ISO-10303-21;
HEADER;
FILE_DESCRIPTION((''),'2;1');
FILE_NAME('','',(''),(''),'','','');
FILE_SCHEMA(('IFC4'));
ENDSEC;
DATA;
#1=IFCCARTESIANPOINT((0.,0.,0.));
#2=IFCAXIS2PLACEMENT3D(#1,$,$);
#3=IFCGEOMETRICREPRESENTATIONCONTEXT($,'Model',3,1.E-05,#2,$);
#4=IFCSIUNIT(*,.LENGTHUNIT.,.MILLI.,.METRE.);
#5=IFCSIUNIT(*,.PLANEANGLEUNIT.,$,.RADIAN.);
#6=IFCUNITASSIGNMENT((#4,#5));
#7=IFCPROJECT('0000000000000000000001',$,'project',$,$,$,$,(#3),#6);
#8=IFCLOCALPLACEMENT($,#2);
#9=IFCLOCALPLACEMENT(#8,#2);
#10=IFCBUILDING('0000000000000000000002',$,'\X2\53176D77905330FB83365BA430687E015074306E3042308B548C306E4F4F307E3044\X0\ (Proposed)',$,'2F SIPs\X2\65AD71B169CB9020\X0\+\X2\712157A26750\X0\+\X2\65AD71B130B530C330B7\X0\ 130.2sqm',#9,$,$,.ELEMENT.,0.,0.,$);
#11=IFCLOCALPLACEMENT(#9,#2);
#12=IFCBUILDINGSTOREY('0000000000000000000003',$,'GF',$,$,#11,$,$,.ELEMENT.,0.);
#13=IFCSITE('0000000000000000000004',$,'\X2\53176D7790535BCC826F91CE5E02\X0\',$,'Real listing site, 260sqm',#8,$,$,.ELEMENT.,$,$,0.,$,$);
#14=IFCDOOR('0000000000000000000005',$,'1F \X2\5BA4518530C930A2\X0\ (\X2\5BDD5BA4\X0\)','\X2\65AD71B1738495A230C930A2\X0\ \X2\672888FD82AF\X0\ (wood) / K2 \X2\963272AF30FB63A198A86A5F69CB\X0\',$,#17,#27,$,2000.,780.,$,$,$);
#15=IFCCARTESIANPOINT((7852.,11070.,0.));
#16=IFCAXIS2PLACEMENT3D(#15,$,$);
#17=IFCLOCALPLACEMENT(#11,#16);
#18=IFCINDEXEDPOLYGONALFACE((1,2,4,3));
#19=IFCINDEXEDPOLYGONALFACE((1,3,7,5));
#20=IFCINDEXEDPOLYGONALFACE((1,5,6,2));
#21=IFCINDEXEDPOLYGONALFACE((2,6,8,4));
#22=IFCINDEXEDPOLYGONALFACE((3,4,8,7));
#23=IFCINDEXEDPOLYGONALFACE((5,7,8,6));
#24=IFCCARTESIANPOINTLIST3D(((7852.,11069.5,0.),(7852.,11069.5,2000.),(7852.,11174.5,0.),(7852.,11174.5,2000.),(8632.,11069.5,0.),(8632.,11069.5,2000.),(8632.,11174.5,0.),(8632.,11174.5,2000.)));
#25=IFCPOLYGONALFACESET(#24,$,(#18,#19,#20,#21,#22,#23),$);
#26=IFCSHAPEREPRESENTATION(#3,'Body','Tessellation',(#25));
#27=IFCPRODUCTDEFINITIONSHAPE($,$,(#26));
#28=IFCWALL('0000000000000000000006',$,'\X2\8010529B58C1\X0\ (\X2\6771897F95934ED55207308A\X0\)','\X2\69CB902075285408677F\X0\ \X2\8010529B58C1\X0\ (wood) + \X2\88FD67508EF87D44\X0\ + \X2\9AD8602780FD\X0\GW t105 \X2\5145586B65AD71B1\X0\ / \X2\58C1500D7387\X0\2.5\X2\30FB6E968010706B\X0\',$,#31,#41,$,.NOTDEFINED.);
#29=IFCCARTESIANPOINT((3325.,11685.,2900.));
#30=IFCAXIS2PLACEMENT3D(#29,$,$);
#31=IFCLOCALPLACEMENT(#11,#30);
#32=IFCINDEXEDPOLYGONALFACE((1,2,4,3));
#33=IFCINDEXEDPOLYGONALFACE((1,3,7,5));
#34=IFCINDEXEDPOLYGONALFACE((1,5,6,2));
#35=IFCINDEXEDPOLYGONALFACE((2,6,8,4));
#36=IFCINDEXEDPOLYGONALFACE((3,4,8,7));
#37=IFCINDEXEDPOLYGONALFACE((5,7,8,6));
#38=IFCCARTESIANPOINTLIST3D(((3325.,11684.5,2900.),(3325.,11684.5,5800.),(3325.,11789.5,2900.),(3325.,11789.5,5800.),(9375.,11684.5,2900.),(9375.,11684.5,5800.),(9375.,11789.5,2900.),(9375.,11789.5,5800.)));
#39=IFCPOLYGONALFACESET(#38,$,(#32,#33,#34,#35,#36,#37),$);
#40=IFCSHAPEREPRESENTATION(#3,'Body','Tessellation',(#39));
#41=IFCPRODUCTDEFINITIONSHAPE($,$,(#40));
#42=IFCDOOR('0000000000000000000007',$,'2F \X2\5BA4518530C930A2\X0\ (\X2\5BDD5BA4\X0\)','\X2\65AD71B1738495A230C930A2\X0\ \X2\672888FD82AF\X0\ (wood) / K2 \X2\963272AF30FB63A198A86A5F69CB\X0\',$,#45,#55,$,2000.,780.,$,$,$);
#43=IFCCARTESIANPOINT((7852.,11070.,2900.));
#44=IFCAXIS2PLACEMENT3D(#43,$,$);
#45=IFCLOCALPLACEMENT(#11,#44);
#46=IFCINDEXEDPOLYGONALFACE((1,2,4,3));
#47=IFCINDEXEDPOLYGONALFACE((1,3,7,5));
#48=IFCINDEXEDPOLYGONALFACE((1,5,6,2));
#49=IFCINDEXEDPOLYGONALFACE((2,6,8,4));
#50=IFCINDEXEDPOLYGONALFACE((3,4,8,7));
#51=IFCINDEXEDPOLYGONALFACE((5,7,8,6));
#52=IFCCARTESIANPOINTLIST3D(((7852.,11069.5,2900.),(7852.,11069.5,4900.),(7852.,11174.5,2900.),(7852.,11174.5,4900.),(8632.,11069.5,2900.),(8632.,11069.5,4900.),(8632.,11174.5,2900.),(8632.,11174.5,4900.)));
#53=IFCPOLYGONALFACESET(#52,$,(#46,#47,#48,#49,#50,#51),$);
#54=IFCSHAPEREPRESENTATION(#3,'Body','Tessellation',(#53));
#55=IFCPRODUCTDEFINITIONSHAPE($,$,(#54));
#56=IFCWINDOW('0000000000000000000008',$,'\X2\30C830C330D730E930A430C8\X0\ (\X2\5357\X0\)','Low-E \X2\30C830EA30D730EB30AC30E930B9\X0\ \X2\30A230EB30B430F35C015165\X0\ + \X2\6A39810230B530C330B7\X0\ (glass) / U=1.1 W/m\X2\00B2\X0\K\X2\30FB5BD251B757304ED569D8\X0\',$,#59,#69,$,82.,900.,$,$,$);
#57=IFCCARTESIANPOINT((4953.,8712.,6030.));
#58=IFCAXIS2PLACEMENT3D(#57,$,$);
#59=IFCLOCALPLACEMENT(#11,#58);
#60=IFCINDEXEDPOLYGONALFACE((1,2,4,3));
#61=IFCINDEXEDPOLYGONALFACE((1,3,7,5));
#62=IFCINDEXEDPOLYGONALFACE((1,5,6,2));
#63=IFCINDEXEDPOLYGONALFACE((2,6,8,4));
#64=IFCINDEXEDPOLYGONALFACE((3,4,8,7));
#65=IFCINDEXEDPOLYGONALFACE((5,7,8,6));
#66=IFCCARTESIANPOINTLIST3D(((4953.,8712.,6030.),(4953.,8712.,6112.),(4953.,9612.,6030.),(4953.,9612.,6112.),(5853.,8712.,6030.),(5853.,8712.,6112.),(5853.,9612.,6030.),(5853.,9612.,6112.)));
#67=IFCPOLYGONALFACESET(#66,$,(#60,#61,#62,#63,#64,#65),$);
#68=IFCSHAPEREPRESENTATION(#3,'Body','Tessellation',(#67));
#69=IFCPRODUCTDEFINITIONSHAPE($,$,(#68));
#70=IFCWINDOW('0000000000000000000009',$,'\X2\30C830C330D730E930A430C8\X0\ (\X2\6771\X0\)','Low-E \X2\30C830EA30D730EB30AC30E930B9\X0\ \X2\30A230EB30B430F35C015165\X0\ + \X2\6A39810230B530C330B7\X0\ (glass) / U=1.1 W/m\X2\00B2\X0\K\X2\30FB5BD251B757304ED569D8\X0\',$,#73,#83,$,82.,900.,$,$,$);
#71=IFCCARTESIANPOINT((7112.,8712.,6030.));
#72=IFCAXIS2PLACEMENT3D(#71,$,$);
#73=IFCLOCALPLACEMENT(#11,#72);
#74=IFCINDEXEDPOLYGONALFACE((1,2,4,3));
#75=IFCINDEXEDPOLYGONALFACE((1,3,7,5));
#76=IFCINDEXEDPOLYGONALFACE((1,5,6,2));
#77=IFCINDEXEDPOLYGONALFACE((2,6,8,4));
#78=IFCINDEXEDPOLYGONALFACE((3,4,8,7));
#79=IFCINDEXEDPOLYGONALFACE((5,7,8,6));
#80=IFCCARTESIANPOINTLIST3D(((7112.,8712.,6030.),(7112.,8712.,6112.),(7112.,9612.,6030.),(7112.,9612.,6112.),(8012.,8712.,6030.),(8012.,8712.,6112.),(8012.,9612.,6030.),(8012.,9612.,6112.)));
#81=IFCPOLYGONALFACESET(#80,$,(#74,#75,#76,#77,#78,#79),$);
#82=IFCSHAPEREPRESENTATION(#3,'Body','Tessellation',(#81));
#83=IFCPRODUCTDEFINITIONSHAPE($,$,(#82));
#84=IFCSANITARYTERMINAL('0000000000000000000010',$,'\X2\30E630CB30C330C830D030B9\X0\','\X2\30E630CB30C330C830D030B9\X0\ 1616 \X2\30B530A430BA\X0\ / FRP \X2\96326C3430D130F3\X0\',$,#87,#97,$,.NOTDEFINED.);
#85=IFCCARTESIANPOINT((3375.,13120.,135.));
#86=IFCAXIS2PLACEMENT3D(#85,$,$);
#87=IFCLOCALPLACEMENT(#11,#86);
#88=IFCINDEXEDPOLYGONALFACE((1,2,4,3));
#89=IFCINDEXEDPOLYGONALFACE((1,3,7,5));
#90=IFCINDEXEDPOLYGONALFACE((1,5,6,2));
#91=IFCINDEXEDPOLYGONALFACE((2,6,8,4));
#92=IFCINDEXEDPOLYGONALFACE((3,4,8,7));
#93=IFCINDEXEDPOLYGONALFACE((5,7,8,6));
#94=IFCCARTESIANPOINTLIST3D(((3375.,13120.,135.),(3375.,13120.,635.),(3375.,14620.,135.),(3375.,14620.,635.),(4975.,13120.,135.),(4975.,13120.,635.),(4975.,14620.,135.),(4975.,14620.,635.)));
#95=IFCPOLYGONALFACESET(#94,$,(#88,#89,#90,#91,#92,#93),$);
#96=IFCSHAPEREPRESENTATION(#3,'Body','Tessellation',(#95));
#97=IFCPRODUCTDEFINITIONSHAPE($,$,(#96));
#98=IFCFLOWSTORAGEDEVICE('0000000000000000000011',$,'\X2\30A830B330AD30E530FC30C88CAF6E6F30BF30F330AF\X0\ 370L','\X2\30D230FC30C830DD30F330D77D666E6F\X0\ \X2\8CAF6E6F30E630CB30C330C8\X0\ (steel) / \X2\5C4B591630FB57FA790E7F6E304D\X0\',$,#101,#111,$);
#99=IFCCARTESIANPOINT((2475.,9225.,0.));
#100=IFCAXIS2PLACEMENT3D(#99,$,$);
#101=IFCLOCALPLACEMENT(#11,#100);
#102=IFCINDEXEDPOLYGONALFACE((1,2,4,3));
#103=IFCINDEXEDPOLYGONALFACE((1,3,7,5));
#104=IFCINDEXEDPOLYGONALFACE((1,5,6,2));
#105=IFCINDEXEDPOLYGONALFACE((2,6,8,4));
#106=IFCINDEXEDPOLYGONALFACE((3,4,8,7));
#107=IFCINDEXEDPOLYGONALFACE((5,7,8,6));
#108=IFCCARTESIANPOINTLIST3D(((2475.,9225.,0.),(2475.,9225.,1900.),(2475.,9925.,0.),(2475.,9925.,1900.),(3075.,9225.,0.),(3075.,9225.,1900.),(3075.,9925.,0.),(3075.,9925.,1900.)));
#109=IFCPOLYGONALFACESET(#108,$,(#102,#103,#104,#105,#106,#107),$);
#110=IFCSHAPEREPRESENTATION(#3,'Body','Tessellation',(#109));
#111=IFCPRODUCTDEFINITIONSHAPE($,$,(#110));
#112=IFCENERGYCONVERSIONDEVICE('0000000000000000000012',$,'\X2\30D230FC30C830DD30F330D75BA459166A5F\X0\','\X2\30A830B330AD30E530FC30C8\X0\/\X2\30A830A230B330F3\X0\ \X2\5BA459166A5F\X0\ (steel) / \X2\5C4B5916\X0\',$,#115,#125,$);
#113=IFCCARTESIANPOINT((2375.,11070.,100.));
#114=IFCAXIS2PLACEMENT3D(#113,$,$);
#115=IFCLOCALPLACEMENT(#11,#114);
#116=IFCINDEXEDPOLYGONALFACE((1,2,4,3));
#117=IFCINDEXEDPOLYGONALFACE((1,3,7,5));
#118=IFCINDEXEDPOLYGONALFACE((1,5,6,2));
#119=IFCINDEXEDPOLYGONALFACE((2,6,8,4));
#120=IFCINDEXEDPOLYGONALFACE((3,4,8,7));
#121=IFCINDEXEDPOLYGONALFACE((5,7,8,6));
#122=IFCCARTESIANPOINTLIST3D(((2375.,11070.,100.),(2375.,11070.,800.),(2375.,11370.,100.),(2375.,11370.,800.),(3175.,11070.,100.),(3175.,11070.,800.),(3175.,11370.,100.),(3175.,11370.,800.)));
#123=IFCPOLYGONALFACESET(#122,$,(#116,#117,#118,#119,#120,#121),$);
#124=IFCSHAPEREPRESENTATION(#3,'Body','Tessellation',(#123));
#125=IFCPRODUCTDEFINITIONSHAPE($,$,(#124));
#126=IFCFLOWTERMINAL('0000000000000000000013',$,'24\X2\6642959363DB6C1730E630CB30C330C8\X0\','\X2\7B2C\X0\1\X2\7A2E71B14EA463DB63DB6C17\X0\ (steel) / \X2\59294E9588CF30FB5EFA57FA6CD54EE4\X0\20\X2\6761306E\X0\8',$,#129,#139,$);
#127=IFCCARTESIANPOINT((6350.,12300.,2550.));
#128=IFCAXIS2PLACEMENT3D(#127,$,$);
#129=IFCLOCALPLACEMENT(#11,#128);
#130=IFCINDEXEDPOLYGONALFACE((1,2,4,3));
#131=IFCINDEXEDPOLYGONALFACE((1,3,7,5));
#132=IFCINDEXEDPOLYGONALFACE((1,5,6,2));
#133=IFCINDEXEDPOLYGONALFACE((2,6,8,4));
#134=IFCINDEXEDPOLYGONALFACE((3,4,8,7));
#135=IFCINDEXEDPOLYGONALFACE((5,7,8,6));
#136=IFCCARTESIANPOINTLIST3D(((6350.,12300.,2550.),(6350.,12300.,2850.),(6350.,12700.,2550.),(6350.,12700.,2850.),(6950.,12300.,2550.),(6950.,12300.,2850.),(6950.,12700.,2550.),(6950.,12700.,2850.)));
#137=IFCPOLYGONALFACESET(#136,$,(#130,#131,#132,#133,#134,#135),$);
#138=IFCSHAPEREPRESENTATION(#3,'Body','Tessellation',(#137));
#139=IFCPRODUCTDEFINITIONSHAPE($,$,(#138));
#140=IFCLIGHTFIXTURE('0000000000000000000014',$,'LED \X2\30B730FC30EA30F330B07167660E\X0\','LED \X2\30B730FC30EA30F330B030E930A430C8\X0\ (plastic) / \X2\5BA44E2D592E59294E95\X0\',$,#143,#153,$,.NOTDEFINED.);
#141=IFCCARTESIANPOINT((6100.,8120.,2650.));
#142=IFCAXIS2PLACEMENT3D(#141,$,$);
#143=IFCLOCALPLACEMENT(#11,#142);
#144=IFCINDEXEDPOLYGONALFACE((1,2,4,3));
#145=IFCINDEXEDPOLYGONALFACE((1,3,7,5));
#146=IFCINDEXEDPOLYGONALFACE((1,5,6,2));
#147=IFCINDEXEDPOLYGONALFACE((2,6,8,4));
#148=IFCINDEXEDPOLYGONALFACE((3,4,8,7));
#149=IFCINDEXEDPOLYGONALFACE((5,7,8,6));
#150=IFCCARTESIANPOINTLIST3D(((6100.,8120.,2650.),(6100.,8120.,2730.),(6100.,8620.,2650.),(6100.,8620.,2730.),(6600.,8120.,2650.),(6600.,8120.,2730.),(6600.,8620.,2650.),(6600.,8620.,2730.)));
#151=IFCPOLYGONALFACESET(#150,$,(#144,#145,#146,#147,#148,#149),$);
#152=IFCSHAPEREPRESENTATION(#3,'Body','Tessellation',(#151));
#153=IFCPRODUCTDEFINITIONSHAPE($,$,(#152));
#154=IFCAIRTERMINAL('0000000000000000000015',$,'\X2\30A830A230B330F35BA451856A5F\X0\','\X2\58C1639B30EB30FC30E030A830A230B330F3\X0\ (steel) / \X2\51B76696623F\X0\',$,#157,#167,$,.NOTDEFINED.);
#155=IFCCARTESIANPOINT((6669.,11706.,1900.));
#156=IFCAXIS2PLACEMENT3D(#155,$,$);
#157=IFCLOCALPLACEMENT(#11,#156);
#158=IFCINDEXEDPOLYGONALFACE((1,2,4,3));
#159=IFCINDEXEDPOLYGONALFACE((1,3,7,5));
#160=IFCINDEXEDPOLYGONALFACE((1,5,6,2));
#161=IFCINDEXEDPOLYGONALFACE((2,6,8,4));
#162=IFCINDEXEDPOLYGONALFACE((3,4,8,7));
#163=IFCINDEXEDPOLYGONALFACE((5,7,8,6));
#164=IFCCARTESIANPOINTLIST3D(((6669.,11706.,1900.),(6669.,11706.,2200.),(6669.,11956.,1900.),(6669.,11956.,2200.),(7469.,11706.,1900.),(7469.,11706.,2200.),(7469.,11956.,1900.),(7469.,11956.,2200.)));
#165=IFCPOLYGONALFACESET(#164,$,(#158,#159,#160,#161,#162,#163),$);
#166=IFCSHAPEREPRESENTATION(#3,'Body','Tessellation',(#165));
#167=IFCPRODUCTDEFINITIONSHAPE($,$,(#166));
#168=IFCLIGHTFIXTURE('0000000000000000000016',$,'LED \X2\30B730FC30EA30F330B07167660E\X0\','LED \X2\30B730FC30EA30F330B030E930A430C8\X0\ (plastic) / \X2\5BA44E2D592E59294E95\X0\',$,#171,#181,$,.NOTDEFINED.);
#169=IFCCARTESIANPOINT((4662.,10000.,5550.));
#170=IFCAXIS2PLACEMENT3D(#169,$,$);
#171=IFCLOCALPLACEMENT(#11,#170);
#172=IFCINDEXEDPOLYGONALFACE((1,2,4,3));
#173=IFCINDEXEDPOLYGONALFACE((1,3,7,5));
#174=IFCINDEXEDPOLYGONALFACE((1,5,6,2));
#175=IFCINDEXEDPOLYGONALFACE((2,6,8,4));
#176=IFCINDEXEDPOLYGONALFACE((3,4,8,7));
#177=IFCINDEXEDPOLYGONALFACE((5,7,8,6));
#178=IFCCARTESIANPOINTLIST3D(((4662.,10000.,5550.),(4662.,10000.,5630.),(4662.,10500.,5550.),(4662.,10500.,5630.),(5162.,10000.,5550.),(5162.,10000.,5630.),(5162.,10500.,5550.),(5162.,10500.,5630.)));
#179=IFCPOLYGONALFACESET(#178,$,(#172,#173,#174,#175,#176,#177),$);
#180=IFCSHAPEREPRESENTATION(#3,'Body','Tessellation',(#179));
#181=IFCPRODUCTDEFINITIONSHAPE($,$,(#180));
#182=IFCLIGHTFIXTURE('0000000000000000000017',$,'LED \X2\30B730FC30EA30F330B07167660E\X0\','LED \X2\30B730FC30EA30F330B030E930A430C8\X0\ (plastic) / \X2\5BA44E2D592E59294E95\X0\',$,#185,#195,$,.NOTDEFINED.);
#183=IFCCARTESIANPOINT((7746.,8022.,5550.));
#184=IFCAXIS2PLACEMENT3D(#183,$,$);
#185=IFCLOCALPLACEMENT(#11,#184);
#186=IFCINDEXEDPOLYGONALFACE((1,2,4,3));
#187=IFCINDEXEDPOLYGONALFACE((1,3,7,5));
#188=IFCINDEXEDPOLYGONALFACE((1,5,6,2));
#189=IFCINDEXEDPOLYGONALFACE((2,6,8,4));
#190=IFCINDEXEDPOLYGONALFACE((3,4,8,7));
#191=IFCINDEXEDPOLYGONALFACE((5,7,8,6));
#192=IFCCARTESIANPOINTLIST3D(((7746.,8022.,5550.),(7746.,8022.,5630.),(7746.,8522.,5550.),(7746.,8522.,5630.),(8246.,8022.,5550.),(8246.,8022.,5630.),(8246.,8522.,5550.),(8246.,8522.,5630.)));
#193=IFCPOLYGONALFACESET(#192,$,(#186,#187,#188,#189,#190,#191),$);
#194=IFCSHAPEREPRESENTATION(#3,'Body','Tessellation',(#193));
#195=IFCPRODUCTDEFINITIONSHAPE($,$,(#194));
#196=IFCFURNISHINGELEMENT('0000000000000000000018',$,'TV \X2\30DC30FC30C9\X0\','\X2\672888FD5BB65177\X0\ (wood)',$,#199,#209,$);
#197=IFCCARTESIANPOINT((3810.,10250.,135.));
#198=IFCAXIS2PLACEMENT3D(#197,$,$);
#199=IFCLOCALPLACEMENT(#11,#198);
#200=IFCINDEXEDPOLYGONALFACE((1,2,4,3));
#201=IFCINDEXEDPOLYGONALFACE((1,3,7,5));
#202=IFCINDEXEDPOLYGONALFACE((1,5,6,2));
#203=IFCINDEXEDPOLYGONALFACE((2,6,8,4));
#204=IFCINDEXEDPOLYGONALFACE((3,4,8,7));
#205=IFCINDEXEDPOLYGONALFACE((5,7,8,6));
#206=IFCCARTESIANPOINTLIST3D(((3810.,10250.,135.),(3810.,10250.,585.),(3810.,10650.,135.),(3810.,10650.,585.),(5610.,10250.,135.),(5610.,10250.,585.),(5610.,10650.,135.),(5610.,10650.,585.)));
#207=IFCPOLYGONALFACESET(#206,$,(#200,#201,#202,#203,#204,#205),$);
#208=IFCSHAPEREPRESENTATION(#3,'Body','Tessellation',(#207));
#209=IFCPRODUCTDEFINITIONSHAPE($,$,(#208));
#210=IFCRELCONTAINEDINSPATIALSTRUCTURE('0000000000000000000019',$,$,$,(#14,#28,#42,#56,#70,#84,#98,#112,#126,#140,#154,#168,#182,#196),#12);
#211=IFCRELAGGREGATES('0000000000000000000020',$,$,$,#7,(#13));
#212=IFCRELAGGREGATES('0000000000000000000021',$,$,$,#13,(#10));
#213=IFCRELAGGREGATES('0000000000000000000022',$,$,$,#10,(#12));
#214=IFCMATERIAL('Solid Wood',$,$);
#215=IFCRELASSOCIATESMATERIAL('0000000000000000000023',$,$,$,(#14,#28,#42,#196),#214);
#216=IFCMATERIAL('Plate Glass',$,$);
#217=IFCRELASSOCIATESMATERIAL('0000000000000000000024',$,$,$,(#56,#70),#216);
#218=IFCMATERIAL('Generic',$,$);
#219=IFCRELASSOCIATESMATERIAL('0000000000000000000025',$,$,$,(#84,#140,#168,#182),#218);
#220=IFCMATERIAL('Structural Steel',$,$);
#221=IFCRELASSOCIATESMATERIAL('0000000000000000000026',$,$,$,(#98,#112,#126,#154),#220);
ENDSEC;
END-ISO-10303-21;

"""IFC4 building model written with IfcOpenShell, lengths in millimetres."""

from ifc_helpers import new_model, si_unit, frame, frame_2d, origin, place, context, project, spatial, rectangle, extrude, material, element, save


model = new_model("IFC4")

# Units and contexts
model_context = context("Model", 3, precision=1e-05, world=origin())
ifc_project = project(units=[si_unit("LENGTHUNIT", "METRE", prefix="MILLI"), si_unit("PLANEANGLEUNIT", "RADIAN")], contexts=[model_context])

# Site, building, storey
site_placement = place(None, origin())
site = spatial("IfcSite", under=ifc_project, at=site_placement, Name="北海道富良野市", ObjectType="Real listing site, 260sqm", CompositionType="ELEMENT", RefElevation=0.0)
building_placement = place(site_placement, origin())
building = spatial("IfcBuilding", under=site, at=building_placement, Name="北海道・茶室と縁側のある和の住まい (Proposed)", ObjectType="2F SIPs断熱構造+無垢材+断熱サッシ 130.2sqm", CompositionType="ELEMENT", ElevationOfRefHeight=0.0, ElevationOfTerrain=0.0)
storey_placement = place(building_placement, origin())
storey = spatial("IfcBuildingStorey", under=building, at=storey_placement, Name="GF", CompositionType="ELEMENT", Elevation=0.0)

# Shared definitions
ifc_material_1 = material(Name="Solid Wood")

# Door
door_1_placement = place(storey_placement, frame((7852.0, 11070.0, 0.0)))
element("IfcDoor", 1, at=door_1_placement, inside=storey, material=ifc_material_1, Name="1F 室内ドア (寝室)", Description="断熱玄関ドア 木製芯 (wood) / K2 防犯・採風機構", OverallHeight=2000.0, OverallWidth=780.0, context=model_context, shape_type="SweptSolid", body=[
    extrude(rectangle(XDim=780.0, YDim=105.0, at=frame_2d((390.0, 52.0))), frame((7852.0, 11070.0, 0.0)), (0.0, 0.0, 1.0), 2000.0),
])

# Wall
wall_1_placement = place(storey_placement, frame((3325.0, 11685.0, 2900.0)))
element("IfcWall", 2, at=wall_1_placement, inside=storey, material=ifc_material_1, Name="耐力壁 (東西間仕切り)", Description="構造用合板 耐力壁 (wood) + 製材軸組 + 高性能GW t105 充填断熱 / 壁倍率2.5・準耐火", PredefinedType="NOTDEFINED", context=model_context, shape_type="SweptSolid", body=[
    extrude(rectangle(XDim=6050.0, YDim=105.0, at=frame_2d((3025.0, 52.0))), frame((3325.0, 11685.0, 2900.0)), (0.0, 0.0, 1.0), 2900.0),
])

# Door
door_2_placement = place(storey_placement, frame((7852.0, 11070.0, 2900.0)))
element("IfcDoor", 3, at=door_2_placement, inside=storey, material=ifc_material_1, Name="2F 室内ドア (寝室)", Description="断熱玄関ドア 木製芯 (wood) / K2 防犯・採風機構", OverallHeight=2000.0, OverallWidth=780.0, context=model_context, shape_type="SweptSolid", body=[
    extrude(rectangle(XDim=780.0, YDim=105.0, at=frame_2d((390.0, 52.0))), frame((7852.0, 11070.0, 2900.0)), (0.0, 0.0, 1.0), 2000.0),
])

# Windows
ifc_material_2 = material(Name="Plate Glass")
window_1_placement = place(storey_placement, frame((4953.0, 8712.0, 6030.0)))
element("IfcWindow", 4, at=window_1_placement, inside=storey, material=ifc_material_2, Name="トップライト (南)", Description="Low-E トリプルガラス アルゴン封入 + 樹脂サッシ (glass) / U=1.1 W/m²K・寒冷地仕様", OverallHeight=82.0, OverallWidth=900.0, context=model_context, shape_type="SweptSolid", body=[
    extrude(rectangle(XDim=900.0, YDim=900.0, at=frame_2d((450.0, 450.0))), frame((4953.0, 8712.0, 6030.0)), (0.0, 0.0, 1.0), 82.0),
])
window_2_placement = place(storey_placement, frame((7112.0, 8712.0, 6030.0)))
element("IfcWindow", 5, at=window_2_placement, inside=storey, material=ifc_material_2, Name="トップライト (東)", Description="Low-E トリプルガラス アルゴン封入 + 樹脂サッシ (glass) / U=1.1 W/m²K・寒冷地仕様", OverallHeight=82.0, OverallWidth=900.0, context=model_context, shape_type="SweptSolid", body=[
    extrude(rectangle(XDim=900.0, YDim=900.0, at=frame_2d((450.0, 450.0))), frame((7112.0, 8712.0, 6030.0)), (0.0, 0.0, 1.0), 82.0),
])

# Sanitary terminal
ifc_material_3 = material(Name="Generic")
sanitary_terminal_placement = place(storey_placement, frame((3375.0, 13120.0, 135.0)))
element("IfcSanitaryTerminal", 6, at=sanitary_terminal_placement, inside=storey, material=ifc_material_3, Name="ユニットバス", Description="ユニットバス 1616 サイズ / FRP 防水パン", PredefinedType="NOTDEFINED", context=model_context, shape_type="SweptSolid", body=[
    extrude(rectangle(XDim=1600.0, YDim=1500.0, at=frame_2d((800.0, 750.0))), frame((3375.0, 13120.0, 135.0)), (0.0, 0.0, 1.0), 500.0),
])

# Flow storage device
ifc_material_4 = material(Name="Structural Steel")
flow_storage_device_placement = place(storey_placement, frame((2475.0, 9225.0, 0.0)))
element("IfcFlowStorageDevice", 7, at=flow_storage_device_placement, inside=storey, material=ifc_material_4, Name="エコキュート貯湯タンク 370L", Description="ヒートポンプ給湯 貯湯ユニット (steel) / 屋外・基礎置き", context=model_context, shape_type="SweptSolid", body=[
    extrude(rectangle(XDim=600.0, YDim=700.0, at=frame_2d((300.0, 350.0))), frame((2475.0, 9225.0, 0.0)), (0.0, 0.0, 1.0), 1900.0),
])

# Energy conversion device
energy_conversion_device_placement = place(storey_placement, frame((2375.0, 11070.0, 100.0)))
element("IfcEnergyConversionDevice", 8, at=energy_conversion_device_placement, inside=storey, material=ifc_material_4, Name="ヒートポンプ室外機", Description="エコキュート/エアコン 室外機 (steel) / 屋外", context=model_context, shape_type="SweptSolid", body=[
    extrude(rectangle(XDim=800.0, YDim=300.0, at=frame_2d((400.0, 150.0))), frame((2375.0, 11070.0, 100.0)), (0.0, 0.0, 1.0), 700.0),
])

# Flow terminal
flow_terminal_placement = place(storey_placement, frame((6350.0, 12300.0, 2550.0)))
element("IfcFlowTerminal", 9, at=flow_terminal_placement, inside=storey, material=ifc_material_4, Name="24時間換気ユニット", Description="第1種熱交換換気 (steel) / 天井裏・建基法令20条の8", context=model_context, shape_type="SweptSolid", body=[
    extrude(rectangle(XDim=600.0, YDim=400.0, at=frame_2d((300.0, 200.0))), frame((6350.0, 12300.0, 2550.0)), (0.0, 0.0, 1.0), 300.0),
])

# Light fixture
light_fixture_1_placement = place(storey_placement, frame((6100.0, 8120.0, 2650.0)))
element("IfcLightFixture", 10, at=light_fixture_1_placement, inside=storey, material=ifc_material_3, Name="LED シーリング照明", Description="LED シーリングライト (plastic) / 室中央天井", PredefinedType="NOTDEFINED", context=model_context, shape_type="SweptSolid", body=[
    extrude(rectangle(XDim=500.0, YDim=500.0, at=frame_2d((250.0, 250.0))), frame((6100.0, 8120.0, 2650.0)), (0.0, 0.0, 1.0), 80.0),
])

# Air terminal
air_terminal_placement = place(storey_placement, frame((6669.0, 11706.0, 1900.0)))
element("IfcAirTerminal", 11, at=air_terminal_placement, inside=storey, material=ifc_material_4, Name="エアコン室内機", Description="壁掛ルームエアコン (steel) / 冷暖房", PredefinedType="NOTDEFINED", context=model_context, shape_type="SweptSolid", body=[
    extrude(rectangle(XDim=800.0, YDim=250.0, at=frame_2d((400.0, 125.0))), frame((6669.0, 11706.0, 1900.0)), (0.0, 0.0, 1.0), 300.0),
])

# Light fixtures
light_fixture_2_placement = place(storey_placement, frame((4662.0, 10000.0, 5550.0)))
element("IfcLightFixture", 12, at=light_fixture_2_placement, inside=storey, material=ifc_material_3, Name="LED シーリング照明", Description="LED シーリングライト (plastic) / 室中央天井", PredefinedType="NOTDEFINED", context=model_context, shape_type="SweptSolid", body=[
    extrude(rectangle(XDim=500.0, YDim=500.0, at=frame_2d((250.0, 250.0))), frame((4662.0, 10000.0, 5550.0)), (0.0, 0.0, 1.0), 80.0),
])
light_fixture_3_placement = place(storey_placement, frame((7746.0, 8022.0, 5550.0)))
element("IfcLightFixture", 13, at=light_fixture_3_placement, inside=storey, material=ifc_material_3, Name="LED シーリング照明", Description="LED シーリングライト (plastic) / 室中央天井", PredefinedType="NOTDEFINED", context=model_context, shape_type="SweptSolid", body=[
    extrude(rectangle(XDim=500.0, YDim=500.0, at=frame_2d((250.0, 250.0))), frame((7746.0, 8022.0, 5550.0)), (0.0, 0.0, 1.0), 80.0),
])

# Furnishing element
furnishing_1_placement = place(storey_placement, frame((3810.0, 10250.0, 135.0)))
element("IfcFurnishingElement", 14, at=furnishing_1_placement, inside=storey, material=ifc_material_1, Name="TV ボード", Description="木製家具 (wood)", context=model_context, shape_type="SweptSolid", body=[
    extrude(rectangle(XDim=1800.0, YDim=400.0, at=frame_2d((900.0, 200.0))), frame((3810.0, 10250.0, 135.0)), (0.0, 0.0, 1.0), 450.0),
])

save(model, "model.ifc")
